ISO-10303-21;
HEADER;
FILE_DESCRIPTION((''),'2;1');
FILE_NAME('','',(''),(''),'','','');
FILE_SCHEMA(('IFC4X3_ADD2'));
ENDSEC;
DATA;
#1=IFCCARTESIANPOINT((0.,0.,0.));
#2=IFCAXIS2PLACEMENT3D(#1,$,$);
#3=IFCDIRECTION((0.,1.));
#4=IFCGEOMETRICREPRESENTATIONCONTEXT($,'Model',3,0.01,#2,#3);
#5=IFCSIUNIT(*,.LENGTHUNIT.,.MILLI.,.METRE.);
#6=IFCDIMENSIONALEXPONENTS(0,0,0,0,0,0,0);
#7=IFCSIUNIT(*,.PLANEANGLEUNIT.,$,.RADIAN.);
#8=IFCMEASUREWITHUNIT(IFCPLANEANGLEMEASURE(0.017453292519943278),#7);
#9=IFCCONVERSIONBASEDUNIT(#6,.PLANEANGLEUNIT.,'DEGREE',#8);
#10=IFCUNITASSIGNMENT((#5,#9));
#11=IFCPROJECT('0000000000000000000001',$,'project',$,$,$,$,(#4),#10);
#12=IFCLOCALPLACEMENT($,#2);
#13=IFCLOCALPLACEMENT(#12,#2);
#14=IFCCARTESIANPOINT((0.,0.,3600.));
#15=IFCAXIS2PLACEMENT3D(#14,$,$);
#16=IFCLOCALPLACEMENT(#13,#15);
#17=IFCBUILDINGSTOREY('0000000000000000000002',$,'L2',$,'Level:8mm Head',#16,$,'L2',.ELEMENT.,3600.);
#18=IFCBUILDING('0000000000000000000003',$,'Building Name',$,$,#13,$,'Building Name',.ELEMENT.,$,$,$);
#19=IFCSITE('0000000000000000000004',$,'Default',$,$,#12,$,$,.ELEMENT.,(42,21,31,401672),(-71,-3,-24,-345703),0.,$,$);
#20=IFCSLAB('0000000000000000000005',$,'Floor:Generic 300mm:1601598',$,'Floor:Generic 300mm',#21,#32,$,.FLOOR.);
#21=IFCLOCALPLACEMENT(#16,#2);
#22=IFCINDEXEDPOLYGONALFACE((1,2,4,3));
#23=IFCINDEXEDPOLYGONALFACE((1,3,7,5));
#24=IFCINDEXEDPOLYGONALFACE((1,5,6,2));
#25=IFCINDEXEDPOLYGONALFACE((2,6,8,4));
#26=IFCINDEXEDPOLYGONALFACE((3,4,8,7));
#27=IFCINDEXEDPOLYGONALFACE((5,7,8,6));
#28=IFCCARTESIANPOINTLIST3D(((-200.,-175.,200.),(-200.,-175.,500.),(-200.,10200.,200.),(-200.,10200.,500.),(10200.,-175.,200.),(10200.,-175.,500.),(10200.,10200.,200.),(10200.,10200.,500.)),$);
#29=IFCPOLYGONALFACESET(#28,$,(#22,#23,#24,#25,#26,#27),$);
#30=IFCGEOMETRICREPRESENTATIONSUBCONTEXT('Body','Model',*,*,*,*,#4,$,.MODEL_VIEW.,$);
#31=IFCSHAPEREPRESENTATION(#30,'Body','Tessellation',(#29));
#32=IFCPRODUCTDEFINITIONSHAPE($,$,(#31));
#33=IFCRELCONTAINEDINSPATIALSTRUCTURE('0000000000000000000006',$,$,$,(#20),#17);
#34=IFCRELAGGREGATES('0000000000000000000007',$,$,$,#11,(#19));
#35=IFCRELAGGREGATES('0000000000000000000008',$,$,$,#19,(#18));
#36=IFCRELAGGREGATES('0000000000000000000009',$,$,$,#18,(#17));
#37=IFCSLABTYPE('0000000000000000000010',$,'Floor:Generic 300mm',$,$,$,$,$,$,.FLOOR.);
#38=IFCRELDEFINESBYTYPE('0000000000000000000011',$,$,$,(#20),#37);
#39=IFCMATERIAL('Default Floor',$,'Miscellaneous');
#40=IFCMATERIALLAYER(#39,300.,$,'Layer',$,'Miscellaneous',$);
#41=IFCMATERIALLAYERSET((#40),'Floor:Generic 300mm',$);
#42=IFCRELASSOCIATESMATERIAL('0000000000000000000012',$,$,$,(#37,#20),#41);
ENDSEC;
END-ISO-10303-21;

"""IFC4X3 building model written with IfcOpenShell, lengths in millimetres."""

from ifc_helpers import new_model, entity, si_unit, converted_unit, direction, frame, frame_2d, origin, place, context, subcontext, project, spatial, rectangle, extrude, material, layer, layer_set, layer_usage, type_object, element, save


model = new_model("IFC4X3")

# Units and contexts
model_context = context("Model", 3, precision=0.01, world=origin(), true_north=direction((0.0, 1.0)))
body_context = subcontext(model_context, "Body", "Model", "MODEL_VIEW")
ifc_project = project(units=[si_unit("LENGTHUNIT", "METRE", prefix="MILLI"), converted_unit("PLANEANGLEUNIT", "DEGREE", entity("IfcPlaneAngleMeasure", 0.017453292519943278), si_unit("PLANEANGLEUNIT", "RADIAN"), dimensions=[0, 0, 0, 0, 0, 0, 0])], contexts=[model_context])

# Site, building, storey
site_placement = place(None, origin())
site = spatial("IfcSite", under=ifc_project, at=site_placement, Name="Default", CompositionType="ELEMENT", RefLatitude=(42, 21, 31, 401672), RefLongitude=(-71, -3, -24, -345703), RefElevation=0.0)
building_placement = place(site_placement, origin())
building = spatial("IfcBuilding", under=site, at=building_placement, Name="Building Name", LongName="Building Name", CompositionType="ELEMENT")
storey_placement = place(building_placement, frame((0.0, 0.0, 3600.0)))
storey = spatial("IfcBuildingStorey", under=building, at=storey_placement, Name="L2", ObjectType="Level:8mm Head", LongName="L2", CompositionType="ELEMENT", Elevation=3600.0)

# Slab
ifc_material = material(Name="Default Floor", Category="Miscellaneous")
ifc_layer = layer(ifc_material, 300.0, Name="Layer", Category="Miscellaneous")
ifc_layer_set = layer_set([ifc_layer], Name="Floor:Generic 300mm")
ifc_layer_usage = layer_usage(ifc_layer_set, "AXIS3", "POSITIVE", 0.0)
slab_type = type_object("IfcSlabType", Name="Floor:Generic 300mm", PredefinedType="FLOOR", material=ifc_layer_set)
slab_placement = place(storey_placement, origin())
element("IfcSlab", 1, at=slab_placement, inside=storey, type_object=slab_type, material=ifc_layer_usage, Name="Floor:Generic 300mm:1601598", ObjectType="Floor:Generic 300mm", PredefinedType="FLOOR", context=body_context, shape_type="SweptSolid", body=[
    extrude(rectangle(XDim=10375.0, YDim=10400.0, at=frame_2d((0.0, 0.0), x_axis=(1.0, 0.0))), frame((5000.0, 5012.5, 500.0), z_axis=(0.0, 0.0, -1.0), x_axis=(0.0, 1.0, 0.0)), (0.0, 0.0, 1.0), 300.0),
])

save(model, "model.ifc")
